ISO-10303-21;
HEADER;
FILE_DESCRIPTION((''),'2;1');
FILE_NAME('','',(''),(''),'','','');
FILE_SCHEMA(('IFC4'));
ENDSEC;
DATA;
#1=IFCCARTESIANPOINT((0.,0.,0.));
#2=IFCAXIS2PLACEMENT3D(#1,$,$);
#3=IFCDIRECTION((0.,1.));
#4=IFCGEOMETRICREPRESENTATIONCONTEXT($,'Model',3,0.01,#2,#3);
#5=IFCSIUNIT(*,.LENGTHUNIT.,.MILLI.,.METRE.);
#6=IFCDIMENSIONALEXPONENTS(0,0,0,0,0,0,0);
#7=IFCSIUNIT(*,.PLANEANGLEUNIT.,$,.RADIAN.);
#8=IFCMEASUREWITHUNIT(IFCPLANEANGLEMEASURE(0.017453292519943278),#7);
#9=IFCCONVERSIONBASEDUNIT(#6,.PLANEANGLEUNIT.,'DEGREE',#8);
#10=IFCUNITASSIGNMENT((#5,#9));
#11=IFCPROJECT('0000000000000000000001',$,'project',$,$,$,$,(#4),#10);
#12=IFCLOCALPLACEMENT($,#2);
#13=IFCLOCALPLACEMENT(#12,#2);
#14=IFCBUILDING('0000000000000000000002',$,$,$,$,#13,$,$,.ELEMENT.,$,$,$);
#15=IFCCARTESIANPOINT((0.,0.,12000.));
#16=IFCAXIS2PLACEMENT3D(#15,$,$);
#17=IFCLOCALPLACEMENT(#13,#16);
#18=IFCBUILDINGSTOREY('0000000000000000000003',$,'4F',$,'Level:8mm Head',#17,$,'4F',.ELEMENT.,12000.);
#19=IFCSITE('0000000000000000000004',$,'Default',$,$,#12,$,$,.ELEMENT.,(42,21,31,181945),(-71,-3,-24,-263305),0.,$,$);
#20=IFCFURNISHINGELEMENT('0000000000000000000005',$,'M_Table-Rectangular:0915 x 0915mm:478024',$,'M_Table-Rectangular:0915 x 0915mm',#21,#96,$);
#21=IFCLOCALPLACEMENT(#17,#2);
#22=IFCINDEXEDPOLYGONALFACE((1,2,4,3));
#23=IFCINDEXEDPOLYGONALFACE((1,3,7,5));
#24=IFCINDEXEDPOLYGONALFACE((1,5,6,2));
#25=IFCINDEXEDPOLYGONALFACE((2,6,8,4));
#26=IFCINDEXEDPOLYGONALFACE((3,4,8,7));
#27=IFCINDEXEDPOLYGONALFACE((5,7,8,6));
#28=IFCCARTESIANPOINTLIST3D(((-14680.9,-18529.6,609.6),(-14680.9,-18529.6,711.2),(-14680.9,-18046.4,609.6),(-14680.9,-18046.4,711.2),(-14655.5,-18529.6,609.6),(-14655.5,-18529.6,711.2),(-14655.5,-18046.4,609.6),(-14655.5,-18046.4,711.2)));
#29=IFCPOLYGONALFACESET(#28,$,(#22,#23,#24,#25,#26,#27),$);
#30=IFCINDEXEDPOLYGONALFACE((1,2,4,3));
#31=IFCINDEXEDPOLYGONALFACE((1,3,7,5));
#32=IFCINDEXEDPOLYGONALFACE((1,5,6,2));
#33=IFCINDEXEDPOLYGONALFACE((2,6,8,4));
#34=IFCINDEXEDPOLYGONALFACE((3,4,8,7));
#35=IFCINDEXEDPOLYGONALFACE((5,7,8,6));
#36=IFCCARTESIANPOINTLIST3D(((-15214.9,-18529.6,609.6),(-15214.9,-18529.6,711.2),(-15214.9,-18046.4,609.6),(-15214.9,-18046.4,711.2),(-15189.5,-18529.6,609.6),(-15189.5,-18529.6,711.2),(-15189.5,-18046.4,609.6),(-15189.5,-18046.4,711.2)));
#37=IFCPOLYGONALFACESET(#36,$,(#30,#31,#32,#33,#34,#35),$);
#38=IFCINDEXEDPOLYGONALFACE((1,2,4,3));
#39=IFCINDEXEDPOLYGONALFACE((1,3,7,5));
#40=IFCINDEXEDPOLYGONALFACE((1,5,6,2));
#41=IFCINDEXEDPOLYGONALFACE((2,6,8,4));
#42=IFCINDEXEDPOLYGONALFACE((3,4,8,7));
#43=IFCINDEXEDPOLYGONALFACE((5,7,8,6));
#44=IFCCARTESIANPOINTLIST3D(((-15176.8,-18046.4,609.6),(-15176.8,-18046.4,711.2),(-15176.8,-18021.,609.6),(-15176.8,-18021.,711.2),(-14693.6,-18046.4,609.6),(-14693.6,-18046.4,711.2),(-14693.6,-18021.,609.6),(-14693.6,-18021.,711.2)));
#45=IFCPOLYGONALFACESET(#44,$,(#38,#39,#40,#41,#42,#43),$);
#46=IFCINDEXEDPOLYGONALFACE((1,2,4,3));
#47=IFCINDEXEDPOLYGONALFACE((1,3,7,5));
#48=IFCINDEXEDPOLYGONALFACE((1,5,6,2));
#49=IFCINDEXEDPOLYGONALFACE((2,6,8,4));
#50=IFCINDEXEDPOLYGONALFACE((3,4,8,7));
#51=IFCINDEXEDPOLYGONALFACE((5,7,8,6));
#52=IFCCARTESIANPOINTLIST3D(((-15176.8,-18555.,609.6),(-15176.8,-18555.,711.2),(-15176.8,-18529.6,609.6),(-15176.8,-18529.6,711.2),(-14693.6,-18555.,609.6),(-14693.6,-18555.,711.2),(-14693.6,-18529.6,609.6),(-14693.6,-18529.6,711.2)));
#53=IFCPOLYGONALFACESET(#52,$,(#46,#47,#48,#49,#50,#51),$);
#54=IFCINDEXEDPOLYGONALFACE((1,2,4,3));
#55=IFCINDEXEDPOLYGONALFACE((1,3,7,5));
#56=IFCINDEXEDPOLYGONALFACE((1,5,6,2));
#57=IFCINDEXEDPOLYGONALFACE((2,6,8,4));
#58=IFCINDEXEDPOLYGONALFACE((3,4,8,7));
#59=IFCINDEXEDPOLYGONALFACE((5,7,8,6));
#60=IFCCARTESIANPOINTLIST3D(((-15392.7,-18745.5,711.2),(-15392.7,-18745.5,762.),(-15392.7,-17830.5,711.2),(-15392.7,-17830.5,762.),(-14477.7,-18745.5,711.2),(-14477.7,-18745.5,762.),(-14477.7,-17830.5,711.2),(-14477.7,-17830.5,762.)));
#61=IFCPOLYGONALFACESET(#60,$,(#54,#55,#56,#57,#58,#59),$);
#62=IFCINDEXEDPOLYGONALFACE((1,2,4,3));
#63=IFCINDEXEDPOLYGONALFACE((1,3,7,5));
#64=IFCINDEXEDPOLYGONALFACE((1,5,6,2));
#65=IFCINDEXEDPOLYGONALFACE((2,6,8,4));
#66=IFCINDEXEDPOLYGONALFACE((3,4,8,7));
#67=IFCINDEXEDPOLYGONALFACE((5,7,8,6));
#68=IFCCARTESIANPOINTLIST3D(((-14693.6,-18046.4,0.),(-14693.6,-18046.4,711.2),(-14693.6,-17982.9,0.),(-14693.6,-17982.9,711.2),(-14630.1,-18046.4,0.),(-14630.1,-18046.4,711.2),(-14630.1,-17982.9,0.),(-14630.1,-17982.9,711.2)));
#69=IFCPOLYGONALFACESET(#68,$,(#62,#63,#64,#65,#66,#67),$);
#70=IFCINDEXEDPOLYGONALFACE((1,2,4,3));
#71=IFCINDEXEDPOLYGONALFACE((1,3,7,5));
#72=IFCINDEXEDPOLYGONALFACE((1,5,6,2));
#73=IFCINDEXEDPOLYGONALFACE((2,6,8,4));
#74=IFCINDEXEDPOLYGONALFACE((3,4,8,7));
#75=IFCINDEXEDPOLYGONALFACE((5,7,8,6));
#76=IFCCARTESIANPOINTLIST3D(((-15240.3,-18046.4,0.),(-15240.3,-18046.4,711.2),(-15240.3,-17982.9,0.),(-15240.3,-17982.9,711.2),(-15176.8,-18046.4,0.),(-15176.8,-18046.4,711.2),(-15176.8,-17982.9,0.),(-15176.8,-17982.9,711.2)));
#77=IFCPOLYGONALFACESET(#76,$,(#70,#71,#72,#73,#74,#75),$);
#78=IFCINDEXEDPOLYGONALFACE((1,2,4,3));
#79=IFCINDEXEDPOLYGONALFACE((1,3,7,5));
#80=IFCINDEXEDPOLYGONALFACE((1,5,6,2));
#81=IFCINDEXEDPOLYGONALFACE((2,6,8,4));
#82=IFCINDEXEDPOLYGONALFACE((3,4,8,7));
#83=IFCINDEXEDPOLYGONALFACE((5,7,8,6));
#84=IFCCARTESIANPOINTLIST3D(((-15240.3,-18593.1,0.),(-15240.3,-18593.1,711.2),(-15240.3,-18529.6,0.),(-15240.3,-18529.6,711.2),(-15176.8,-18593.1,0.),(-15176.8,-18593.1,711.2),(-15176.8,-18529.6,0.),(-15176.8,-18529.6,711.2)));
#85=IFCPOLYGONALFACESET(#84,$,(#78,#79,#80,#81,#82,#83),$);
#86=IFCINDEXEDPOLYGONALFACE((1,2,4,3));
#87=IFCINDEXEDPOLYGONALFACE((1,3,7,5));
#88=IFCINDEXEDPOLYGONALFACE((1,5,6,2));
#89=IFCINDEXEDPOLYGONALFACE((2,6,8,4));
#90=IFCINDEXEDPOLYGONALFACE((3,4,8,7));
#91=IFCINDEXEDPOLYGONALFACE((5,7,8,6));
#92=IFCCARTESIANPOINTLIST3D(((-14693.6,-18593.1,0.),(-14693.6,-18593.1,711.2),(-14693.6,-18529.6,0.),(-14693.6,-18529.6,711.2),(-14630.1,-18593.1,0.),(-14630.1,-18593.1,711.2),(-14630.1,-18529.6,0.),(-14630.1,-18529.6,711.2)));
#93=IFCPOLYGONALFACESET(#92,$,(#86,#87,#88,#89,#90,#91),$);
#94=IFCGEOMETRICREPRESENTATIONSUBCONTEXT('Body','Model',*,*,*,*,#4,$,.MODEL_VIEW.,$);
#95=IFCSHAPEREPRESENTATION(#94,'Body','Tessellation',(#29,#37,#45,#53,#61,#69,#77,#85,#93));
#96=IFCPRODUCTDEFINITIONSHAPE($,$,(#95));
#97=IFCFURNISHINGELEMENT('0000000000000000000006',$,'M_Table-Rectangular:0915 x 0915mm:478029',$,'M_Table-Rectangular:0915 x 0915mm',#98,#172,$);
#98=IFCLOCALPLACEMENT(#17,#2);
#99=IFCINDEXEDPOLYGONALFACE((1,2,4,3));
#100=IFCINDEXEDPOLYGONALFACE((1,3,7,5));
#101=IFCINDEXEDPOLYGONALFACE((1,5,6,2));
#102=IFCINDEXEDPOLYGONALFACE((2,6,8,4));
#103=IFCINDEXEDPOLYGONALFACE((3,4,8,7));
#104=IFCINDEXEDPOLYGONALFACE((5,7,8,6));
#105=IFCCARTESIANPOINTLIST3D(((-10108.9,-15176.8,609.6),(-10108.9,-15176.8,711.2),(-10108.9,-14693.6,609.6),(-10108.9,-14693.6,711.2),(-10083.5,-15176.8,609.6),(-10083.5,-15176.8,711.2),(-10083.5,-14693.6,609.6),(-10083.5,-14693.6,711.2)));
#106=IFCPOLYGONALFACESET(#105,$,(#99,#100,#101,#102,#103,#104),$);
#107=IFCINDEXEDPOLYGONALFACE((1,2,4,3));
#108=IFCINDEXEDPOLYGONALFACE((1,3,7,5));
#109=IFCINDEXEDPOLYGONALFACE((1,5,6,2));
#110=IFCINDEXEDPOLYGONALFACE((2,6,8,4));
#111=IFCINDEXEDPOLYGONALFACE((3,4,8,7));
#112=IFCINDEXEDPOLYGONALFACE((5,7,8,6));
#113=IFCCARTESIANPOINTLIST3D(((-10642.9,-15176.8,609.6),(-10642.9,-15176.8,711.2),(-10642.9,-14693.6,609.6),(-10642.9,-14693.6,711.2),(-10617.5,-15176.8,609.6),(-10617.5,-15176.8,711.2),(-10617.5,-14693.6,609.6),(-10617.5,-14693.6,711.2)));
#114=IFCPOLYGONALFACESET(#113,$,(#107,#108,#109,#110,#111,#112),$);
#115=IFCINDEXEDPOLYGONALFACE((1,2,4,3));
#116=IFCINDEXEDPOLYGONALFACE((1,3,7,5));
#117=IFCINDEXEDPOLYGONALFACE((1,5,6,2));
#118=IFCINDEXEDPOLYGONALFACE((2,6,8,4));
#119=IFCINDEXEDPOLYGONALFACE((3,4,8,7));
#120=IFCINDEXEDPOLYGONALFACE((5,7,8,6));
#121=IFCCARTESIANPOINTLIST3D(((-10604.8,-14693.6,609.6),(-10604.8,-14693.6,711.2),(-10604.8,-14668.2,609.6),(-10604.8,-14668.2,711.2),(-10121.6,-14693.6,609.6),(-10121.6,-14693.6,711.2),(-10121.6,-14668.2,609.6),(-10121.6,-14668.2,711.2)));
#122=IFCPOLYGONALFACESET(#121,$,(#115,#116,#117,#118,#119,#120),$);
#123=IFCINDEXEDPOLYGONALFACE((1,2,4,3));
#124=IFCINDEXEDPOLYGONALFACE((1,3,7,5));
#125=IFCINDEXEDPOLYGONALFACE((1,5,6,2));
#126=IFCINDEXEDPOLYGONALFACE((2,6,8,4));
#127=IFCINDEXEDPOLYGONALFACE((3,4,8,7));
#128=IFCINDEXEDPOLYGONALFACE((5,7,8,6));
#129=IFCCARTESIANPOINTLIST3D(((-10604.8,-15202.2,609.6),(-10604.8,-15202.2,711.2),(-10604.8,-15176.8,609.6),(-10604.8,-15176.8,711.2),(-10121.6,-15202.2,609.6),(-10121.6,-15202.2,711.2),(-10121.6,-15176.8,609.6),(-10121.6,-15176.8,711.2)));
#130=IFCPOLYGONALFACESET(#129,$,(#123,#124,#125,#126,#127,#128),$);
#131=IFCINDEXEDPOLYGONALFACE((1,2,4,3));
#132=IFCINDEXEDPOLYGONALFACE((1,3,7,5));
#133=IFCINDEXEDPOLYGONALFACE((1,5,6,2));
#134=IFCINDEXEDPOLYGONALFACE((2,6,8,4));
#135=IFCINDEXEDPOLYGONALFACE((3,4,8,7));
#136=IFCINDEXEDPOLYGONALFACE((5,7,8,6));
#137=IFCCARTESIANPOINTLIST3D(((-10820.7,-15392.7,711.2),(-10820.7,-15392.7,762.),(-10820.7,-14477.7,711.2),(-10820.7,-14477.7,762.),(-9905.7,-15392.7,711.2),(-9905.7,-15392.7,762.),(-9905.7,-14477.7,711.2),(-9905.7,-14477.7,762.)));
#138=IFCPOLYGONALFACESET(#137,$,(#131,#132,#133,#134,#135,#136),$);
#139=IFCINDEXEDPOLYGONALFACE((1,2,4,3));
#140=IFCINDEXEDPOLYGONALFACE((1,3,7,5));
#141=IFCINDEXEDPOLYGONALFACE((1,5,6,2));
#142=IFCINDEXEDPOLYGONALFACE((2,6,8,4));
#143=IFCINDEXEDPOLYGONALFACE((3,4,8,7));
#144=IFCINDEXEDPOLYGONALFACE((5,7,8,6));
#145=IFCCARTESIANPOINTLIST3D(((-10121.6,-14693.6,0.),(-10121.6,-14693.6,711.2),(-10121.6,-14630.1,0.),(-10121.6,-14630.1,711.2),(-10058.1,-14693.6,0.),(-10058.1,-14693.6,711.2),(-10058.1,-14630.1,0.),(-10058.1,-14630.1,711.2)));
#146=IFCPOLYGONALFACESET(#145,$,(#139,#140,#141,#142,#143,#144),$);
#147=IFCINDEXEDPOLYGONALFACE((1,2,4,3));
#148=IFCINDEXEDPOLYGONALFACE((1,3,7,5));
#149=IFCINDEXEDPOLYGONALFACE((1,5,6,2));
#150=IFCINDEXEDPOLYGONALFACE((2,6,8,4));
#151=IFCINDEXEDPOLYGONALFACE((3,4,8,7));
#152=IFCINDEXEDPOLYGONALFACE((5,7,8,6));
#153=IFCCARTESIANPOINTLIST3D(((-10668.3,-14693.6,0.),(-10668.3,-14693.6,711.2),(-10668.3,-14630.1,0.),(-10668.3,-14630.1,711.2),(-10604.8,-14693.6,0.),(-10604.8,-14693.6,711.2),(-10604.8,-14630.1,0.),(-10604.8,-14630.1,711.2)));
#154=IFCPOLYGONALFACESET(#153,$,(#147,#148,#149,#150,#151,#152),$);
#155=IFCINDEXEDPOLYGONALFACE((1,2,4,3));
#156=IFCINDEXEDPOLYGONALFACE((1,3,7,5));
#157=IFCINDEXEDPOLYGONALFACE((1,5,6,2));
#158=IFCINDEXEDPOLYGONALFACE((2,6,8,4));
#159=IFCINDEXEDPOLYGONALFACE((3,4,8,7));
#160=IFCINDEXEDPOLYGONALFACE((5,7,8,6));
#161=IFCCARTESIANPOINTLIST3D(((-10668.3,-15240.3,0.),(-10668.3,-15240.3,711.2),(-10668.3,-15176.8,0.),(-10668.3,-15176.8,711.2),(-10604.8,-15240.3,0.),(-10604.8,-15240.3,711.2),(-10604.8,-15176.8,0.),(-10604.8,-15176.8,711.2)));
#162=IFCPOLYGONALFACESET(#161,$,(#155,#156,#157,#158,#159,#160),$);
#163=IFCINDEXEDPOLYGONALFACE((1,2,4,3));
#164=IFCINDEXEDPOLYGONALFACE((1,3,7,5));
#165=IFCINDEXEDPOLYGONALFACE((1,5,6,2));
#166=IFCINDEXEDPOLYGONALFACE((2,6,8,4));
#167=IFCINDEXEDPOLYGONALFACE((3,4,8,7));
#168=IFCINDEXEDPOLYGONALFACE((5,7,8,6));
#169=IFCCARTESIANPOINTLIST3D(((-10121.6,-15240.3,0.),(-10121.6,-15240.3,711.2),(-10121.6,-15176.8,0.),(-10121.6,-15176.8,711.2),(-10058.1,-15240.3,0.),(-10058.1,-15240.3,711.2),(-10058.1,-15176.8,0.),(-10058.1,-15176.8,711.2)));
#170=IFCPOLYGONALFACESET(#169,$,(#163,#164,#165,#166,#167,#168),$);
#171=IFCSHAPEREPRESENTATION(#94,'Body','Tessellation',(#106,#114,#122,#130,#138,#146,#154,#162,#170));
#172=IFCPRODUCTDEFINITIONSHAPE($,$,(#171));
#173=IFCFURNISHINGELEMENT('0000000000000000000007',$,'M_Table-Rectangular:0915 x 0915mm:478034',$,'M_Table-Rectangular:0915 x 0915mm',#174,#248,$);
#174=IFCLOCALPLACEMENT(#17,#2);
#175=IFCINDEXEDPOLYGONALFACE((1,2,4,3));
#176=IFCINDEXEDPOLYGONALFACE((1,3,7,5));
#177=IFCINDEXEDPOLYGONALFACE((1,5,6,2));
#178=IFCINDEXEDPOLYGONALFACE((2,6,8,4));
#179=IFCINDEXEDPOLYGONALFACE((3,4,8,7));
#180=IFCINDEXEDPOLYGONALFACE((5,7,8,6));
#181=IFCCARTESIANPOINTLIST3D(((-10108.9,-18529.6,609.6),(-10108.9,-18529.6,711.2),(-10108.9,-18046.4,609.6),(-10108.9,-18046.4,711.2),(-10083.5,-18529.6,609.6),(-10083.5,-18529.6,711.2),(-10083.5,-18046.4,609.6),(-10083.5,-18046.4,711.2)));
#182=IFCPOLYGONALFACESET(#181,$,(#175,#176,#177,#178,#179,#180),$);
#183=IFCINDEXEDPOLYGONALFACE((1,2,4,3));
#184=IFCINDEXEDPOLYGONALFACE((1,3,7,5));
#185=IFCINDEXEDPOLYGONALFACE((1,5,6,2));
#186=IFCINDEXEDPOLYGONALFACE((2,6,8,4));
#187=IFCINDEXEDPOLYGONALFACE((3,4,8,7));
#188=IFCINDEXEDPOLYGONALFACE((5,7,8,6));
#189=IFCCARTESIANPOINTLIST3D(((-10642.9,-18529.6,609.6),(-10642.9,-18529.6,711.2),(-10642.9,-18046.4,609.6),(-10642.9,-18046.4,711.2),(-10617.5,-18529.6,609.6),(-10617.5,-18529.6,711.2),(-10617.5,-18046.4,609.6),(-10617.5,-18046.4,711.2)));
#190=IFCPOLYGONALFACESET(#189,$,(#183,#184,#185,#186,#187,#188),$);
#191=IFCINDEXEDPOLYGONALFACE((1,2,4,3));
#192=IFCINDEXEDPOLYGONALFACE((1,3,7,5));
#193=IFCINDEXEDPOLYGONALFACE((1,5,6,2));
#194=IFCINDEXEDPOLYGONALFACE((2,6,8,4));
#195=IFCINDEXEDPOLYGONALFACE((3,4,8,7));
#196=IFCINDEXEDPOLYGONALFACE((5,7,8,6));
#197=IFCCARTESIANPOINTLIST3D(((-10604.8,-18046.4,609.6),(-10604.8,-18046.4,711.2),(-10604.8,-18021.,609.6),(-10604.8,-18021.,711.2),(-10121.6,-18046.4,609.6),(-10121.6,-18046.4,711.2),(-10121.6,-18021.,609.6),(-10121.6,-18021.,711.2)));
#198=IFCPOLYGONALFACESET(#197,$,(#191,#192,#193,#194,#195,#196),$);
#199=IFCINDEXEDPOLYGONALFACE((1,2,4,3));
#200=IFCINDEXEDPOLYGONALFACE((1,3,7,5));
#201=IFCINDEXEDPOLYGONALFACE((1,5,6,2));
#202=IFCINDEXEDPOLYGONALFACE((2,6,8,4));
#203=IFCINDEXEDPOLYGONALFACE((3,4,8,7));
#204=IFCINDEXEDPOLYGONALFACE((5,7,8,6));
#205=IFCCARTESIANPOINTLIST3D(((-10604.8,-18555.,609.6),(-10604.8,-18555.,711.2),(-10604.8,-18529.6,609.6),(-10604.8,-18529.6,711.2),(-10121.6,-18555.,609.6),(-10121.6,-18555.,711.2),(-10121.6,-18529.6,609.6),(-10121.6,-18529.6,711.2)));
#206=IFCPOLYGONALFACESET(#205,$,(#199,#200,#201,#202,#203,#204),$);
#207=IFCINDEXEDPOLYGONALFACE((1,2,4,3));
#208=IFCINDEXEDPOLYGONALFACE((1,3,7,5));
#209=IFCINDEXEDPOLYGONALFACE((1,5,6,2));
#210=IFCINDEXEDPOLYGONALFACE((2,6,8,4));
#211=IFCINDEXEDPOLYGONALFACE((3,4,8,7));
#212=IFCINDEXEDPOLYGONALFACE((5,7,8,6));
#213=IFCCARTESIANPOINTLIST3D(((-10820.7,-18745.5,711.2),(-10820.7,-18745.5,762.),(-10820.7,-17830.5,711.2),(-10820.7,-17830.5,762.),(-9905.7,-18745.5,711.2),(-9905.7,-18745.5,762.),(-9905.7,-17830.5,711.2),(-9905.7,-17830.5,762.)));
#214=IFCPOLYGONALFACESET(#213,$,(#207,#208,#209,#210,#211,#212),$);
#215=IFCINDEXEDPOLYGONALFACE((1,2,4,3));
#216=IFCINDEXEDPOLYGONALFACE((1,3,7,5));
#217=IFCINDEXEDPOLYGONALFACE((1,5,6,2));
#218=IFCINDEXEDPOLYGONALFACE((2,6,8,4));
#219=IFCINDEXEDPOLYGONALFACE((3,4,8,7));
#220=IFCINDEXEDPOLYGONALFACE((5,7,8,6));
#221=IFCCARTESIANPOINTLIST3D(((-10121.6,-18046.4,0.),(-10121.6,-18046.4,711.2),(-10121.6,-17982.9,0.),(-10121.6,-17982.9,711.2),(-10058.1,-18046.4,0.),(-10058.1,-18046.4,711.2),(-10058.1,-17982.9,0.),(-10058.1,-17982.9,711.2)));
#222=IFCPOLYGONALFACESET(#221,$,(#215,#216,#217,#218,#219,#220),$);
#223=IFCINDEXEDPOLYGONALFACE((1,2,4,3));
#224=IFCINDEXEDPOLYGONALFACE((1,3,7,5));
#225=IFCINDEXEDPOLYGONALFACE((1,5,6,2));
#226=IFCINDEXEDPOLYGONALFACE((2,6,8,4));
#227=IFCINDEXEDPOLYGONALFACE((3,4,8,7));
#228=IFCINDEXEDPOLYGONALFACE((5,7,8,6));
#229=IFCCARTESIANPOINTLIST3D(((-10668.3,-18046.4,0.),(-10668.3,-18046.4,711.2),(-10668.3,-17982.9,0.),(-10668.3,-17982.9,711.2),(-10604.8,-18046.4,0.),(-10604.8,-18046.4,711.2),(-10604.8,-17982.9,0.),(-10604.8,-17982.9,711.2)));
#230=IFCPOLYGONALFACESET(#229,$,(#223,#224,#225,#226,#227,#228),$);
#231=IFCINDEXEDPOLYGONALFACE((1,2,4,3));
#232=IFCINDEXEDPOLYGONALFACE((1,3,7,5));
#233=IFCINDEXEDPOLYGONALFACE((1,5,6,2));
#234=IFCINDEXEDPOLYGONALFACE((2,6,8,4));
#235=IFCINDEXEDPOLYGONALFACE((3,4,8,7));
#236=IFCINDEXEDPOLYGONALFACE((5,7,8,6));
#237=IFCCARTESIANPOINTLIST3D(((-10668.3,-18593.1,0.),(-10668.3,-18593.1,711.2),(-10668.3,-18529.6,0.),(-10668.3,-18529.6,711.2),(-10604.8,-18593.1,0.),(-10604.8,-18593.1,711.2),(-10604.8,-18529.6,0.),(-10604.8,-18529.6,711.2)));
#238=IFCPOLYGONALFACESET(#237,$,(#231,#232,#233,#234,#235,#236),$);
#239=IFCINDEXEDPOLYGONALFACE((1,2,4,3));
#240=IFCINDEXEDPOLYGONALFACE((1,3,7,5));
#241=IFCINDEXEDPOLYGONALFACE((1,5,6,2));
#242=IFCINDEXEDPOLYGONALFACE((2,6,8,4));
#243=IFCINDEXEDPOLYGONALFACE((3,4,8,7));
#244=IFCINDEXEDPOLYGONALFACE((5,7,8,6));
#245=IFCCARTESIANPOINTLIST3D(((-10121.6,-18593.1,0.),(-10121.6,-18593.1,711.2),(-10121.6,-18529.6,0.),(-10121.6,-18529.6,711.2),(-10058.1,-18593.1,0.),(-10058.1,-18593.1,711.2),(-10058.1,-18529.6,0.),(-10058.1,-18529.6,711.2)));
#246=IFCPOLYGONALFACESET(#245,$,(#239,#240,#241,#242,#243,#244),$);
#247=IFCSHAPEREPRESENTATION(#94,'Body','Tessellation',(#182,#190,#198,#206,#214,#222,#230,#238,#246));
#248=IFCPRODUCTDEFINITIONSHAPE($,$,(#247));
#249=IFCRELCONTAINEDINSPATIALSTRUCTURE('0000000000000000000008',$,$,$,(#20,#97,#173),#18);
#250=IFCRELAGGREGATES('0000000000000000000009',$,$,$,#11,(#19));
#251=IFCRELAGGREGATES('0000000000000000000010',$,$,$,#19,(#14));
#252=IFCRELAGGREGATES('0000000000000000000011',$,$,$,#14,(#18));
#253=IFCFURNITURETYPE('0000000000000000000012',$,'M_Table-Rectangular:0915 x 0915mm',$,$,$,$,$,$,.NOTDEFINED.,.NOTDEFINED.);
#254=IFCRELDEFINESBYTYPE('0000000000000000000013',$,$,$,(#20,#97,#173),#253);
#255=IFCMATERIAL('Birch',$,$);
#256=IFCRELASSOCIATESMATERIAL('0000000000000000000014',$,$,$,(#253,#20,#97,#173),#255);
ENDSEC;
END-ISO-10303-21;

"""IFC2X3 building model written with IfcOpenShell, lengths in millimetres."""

from ifc_helpers import new_model, entity, si_unit, converted_unit, direction, frame, frame_2d, origin, origin_2d_with_axis, place, context, subcontext, project, spatial, rectangle, extrude, source, transform, mapped, material, type_object, type_shapes, element, save


model = new_model("IFC2X3")

# Units and contexts
model_context = context("Model", 3, precision=0.01, world=origin(), true_north=direction((0.0, 1.0)))
body_context = subcontext(model_context, "Body", "Model", "MODEL_VIEW")
ifc_project = project(units=[si_unit("LENGTHUNIT", "METRE", prefix="MILLI"), converted_unit("PLANEANGLEUNIT", "DEGREE", entity("IfcPlaneAngleMeasure", 0.017453292519943278), si_unit("PLANEANGLEUNIT", "RADIAN"), dimensions=[0, 0, 0, 0, 0, 0, 0])], contexts=[model_context])

# Site, building, storey
site_placement = place(None, origin())
site = spatial("IfcSite", under=ifc_project, at=site_placement, Name="Default", CompositionType="ELEMENT", RefLatitude=(42, 21, 31, 181945), RefLongitude=(-71, -3, -24, -263305), RefElevation=0.0)
building_placement = place(site_placement, origin())
building = spatial("IfcBuilding", under=site, at=building_placement, CompositionType="ELEMENT")
storey_placement = place(building_placement, frame((0.0, 0.0, 12000.0)))
storey = spatial("IfcBuildingStorey", under=building, at=storey_placement, Name="4F", ObjectType="Level:8mm Head", LongName="4F", CompositionType="ELEMENT", Elevation=12000.0)

# Furnishing elements
ifc_material_1 = material(Name="Birch")
furniture_type = type_object("IfcFurnitureType", Name="M_Table-Rectangular:0915 x 0915mm", AssemblyPlace="NOTDEFINED", material=ifc_material_1)
shared_shape_1 = source(origin(), body_context, "Body", "SweptSolid", [
    extrude(rectangle(XDim=25.4, YDim=483.2, at=origin_2d_with_axis()), frame((267.0, 0.0, 609.6)), (0.0, 0.0, 1.0), 101.6),
    extrude(rectangle(XDim=483.2, YDim=25.4, at=origin_2d_with_axis()), frame((-267.0, 0.0, 609.6), z_axis=(0.0, 0.0, 1.0), x_axis=(0.0, 1.0, 0.0)), (0.0, 0.0, 1.0), 101.6),
    extrude(rectangle(XDim=483.2, YDim=25.4, at=frame_2d((0.0, 0.0), x_axis=(1.0, 0.0))), frame((0.0, 254.3, 609.6), z_axis=(0.0, 0.0, 1.0), x_axis=(-1.0, 0.0, 0.0)), (0.0, 0.0, 1.0), 101.6),
    extrude(rectangle(XDim=25.4, YDim=483.2, at=origin_2d_with_axis()), frame((0.0, -254.3, 609.6), z_axis=(0.0, 0.0, 1.0), x_axis=(0.0, 1.0, 0.0)), (0.0, 0.0, 1.0), 101.6),
    extrude(rectangle(XDim=915.0, YDim=915.0, at=origin_2d_with_axis()), frame((0.0, 0.0, 711.2), z_axis=(0.0, 0.0, 1.0), x_axis=(-1.0, 0.0, 0.0)), (0.0, 0.0, 1.0), 50.8),
    extrude(rectangle(XDim=63.5, YDim=63.5, at=origin_2d_with_axis()), frame((273.3, 273.4, 0.0), z_axis=(0.0, 0.0, 1.0), x_axis=(0.0, -1.0, 0.0)), (0.0, 0.0, 1.0), 711.2),
    extrude(rectangle(XDim=63.5, YDim=63.5, at=origin_2d_with_axis()), frame((-273.3, 273.4, 0.0), z_axis=(0.0, 0.0, 1.0), x_axis=(-1.0, 0.0, 0.0)), (0.0, 0.0, 1.0), 711.2),
    extrude(rectangle(XDim=63.5, YDim=63.5, at=origin_2d_with_axis()), frame((-273.3, -273.4, 0.0), z_axis=(0.0, 0.0, 1.0), x_axis=(0.0, 1.0, 0.0)), (0.0, 0.0, 1.0), 711.2),
    extrude(rectangle(XDim=63.5, YDim=63.5, at=origin_2d_with_axis()), frame((273.3, -273.4, 0.0)), (0.0, 0.0, 1.0), 711.2),
])
type_shapes(furniture_type, [shared_shape_1])
for number, where, name in (
    (1, (-14935.2, -18288.0, 0.0), "M_Table-Rectangular:0915 x 0915mm:478024"),
    (2, (-10363.2, -14935.2, 0.0), "M_Table-Rectangular:0915 x 0915mm:478029"),
    (3, (-10363.2, -18288.0, 0.0), "M_Table-Rectangular:0915 x 0915mm:478034"),
):
    element("IfcFurnishingElement", number, at=place(storey_placement, frame(where)), inside=storey, type_object=furniture_type, material=ifc_material_1, Name=name, ObjectType="M_Table-Rectangular:0915 x 0915mm", context=body_context, shape_type="MappedRepresentation", body=[
        mapped(shared_shape_1, transform((0.0, 0.0, 0.0), scale=1.0)),
    ])

save(model, "model.ifc")
